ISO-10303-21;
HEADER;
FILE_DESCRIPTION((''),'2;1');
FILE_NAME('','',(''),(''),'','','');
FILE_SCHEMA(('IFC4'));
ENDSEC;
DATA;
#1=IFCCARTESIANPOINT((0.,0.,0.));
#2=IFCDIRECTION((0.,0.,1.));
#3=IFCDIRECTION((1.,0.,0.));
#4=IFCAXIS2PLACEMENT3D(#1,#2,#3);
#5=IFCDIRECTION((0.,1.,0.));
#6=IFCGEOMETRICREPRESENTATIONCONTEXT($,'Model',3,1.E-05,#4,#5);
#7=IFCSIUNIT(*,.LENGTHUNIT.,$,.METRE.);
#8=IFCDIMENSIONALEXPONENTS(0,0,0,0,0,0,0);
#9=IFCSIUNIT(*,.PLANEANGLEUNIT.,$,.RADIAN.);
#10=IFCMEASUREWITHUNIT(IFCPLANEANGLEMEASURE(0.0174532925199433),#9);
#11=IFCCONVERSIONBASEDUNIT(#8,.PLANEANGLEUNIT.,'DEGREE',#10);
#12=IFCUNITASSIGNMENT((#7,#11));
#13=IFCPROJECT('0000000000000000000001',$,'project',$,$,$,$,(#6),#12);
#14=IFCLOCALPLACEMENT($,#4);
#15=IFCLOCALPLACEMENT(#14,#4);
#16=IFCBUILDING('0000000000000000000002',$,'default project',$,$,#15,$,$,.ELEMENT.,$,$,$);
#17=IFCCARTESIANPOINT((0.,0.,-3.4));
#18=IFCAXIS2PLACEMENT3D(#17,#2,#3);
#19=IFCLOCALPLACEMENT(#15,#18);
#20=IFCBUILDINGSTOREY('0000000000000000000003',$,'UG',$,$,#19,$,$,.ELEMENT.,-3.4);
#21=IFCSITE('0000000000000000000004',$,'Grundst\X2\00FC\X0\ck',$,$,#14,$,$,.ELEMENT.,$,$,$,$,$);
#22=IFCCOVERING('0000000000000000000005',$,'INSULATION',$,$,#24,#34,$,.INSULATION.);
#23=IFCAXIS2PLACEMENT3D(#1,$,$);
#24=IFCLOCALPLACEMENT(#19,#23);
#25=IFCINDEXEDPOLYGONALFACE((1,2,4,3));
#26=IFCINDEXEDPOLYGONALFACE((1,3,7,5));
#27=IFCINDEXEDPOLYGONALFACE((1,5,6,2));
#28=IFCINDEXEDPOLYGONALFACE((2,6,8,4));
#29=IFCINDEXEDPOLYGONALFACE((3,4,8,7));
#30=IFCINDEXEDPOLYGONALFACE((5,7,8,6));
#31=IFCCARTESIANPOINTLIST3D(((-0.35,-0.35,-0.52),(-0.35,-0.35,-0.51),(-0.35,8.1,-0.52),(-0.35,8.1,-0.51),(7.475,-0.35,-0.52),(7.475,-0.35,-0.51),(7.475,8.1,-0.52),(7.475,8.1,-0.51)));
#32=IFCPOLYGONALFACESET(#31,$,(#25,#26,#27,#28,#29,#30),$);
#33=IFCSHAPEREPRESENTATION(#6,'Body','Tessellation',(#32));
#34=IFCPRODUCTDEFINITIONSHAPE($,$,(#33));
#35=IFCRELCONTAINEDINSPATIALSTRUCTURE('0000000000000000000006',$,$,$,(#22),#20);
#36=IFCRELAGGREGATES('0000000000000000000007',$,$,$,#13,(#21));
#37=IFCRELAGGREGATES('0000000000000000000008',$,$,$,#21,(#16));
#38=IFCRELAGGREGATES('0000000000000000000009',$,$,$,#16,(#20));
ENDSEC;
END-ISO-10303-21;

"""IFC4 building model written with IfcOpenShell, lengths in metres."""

from ifc_helpers import new_model, entity, si_unit, converted_unit, direction, frame, origin_with_axes, place, context, project, spatial, polyline, outline, extrude, element, save


model = new_model("IFC4")

# Units and contexts
model_context = context("Model", 3, precision=1e-05, world=origin_with_axes(), true_north=direction((0.0, 1.0, 0.0)))
ifc_project = project(units=[si_unit("LENGTHUNIT", "METRE"), converted_unit("PLANEANGLEUNIT", "DEGREE", entity("IfcPlaneAngleMeasure", 0.0174532925199433), si_unit("PLANEANGLEUNIT", "RADIAN"), dimensions=[0, 0, 0, 0, 0, 0, 0])], contexts=[model_context])

# Site, building, storey
site_placement = place(None, origin_with_axes())
site = spatial("IfcSite", under=ifc_project, at=site_placement, Name="Grundstück", CompositionType="ELEMENT")
building_placement = place(site_placement, origin_with_axes())
building = spatial("IfcBuilding", under=site, at=building_placement, Name="default project", CompositionType="ELEMENT")
placement_1 = place(building_placement, frame((0.0, 0.0, -3.4), z_axis=(0.0, 0.0, 1.0), x_axis=(1.0, 0.0, 0.0)))
storey = spatial("IfcBuildingStorey", under=building, at=placement_1, Name="UG", CompositionType="ELEMENT", Elevation=-3.4)

# Shared definitions
slab_placement = place(placement_1, frame((0.0, 0.0, -0.5), z_axis=(0.0, 0.0, 1.0), x_axis=(1.0, 0.0, 0.0)))

# Covering
covering_1_placement = place(slab_placement, frame((0.0, 0.0, -0.01), z_axis=(0.0, 0.0, 1.0), x_axis=(1.0, 0.0, 0.0)))
element("IfcCovering", 1, at=covering_1_placement, inside=storey, Name="INSULATION", PredefinedType="INSULATION", context=model_context, shape_type="SweptSolid", body=[
    extrude(outline(polyline([(7.475, 8.1), (-0.35, 8.1), (-0.35, -0.35), (7.475, -0.35), (7.475, 8.1)])), frame((0.0, 0.0, -0.01), z_axis=(0.0, 0.0, 1.0), x_axis=(1.0, 0.0, 0.0)), (0.0, 0.0, 1.0), 0.01),
])

save(model, "model.ifc")
